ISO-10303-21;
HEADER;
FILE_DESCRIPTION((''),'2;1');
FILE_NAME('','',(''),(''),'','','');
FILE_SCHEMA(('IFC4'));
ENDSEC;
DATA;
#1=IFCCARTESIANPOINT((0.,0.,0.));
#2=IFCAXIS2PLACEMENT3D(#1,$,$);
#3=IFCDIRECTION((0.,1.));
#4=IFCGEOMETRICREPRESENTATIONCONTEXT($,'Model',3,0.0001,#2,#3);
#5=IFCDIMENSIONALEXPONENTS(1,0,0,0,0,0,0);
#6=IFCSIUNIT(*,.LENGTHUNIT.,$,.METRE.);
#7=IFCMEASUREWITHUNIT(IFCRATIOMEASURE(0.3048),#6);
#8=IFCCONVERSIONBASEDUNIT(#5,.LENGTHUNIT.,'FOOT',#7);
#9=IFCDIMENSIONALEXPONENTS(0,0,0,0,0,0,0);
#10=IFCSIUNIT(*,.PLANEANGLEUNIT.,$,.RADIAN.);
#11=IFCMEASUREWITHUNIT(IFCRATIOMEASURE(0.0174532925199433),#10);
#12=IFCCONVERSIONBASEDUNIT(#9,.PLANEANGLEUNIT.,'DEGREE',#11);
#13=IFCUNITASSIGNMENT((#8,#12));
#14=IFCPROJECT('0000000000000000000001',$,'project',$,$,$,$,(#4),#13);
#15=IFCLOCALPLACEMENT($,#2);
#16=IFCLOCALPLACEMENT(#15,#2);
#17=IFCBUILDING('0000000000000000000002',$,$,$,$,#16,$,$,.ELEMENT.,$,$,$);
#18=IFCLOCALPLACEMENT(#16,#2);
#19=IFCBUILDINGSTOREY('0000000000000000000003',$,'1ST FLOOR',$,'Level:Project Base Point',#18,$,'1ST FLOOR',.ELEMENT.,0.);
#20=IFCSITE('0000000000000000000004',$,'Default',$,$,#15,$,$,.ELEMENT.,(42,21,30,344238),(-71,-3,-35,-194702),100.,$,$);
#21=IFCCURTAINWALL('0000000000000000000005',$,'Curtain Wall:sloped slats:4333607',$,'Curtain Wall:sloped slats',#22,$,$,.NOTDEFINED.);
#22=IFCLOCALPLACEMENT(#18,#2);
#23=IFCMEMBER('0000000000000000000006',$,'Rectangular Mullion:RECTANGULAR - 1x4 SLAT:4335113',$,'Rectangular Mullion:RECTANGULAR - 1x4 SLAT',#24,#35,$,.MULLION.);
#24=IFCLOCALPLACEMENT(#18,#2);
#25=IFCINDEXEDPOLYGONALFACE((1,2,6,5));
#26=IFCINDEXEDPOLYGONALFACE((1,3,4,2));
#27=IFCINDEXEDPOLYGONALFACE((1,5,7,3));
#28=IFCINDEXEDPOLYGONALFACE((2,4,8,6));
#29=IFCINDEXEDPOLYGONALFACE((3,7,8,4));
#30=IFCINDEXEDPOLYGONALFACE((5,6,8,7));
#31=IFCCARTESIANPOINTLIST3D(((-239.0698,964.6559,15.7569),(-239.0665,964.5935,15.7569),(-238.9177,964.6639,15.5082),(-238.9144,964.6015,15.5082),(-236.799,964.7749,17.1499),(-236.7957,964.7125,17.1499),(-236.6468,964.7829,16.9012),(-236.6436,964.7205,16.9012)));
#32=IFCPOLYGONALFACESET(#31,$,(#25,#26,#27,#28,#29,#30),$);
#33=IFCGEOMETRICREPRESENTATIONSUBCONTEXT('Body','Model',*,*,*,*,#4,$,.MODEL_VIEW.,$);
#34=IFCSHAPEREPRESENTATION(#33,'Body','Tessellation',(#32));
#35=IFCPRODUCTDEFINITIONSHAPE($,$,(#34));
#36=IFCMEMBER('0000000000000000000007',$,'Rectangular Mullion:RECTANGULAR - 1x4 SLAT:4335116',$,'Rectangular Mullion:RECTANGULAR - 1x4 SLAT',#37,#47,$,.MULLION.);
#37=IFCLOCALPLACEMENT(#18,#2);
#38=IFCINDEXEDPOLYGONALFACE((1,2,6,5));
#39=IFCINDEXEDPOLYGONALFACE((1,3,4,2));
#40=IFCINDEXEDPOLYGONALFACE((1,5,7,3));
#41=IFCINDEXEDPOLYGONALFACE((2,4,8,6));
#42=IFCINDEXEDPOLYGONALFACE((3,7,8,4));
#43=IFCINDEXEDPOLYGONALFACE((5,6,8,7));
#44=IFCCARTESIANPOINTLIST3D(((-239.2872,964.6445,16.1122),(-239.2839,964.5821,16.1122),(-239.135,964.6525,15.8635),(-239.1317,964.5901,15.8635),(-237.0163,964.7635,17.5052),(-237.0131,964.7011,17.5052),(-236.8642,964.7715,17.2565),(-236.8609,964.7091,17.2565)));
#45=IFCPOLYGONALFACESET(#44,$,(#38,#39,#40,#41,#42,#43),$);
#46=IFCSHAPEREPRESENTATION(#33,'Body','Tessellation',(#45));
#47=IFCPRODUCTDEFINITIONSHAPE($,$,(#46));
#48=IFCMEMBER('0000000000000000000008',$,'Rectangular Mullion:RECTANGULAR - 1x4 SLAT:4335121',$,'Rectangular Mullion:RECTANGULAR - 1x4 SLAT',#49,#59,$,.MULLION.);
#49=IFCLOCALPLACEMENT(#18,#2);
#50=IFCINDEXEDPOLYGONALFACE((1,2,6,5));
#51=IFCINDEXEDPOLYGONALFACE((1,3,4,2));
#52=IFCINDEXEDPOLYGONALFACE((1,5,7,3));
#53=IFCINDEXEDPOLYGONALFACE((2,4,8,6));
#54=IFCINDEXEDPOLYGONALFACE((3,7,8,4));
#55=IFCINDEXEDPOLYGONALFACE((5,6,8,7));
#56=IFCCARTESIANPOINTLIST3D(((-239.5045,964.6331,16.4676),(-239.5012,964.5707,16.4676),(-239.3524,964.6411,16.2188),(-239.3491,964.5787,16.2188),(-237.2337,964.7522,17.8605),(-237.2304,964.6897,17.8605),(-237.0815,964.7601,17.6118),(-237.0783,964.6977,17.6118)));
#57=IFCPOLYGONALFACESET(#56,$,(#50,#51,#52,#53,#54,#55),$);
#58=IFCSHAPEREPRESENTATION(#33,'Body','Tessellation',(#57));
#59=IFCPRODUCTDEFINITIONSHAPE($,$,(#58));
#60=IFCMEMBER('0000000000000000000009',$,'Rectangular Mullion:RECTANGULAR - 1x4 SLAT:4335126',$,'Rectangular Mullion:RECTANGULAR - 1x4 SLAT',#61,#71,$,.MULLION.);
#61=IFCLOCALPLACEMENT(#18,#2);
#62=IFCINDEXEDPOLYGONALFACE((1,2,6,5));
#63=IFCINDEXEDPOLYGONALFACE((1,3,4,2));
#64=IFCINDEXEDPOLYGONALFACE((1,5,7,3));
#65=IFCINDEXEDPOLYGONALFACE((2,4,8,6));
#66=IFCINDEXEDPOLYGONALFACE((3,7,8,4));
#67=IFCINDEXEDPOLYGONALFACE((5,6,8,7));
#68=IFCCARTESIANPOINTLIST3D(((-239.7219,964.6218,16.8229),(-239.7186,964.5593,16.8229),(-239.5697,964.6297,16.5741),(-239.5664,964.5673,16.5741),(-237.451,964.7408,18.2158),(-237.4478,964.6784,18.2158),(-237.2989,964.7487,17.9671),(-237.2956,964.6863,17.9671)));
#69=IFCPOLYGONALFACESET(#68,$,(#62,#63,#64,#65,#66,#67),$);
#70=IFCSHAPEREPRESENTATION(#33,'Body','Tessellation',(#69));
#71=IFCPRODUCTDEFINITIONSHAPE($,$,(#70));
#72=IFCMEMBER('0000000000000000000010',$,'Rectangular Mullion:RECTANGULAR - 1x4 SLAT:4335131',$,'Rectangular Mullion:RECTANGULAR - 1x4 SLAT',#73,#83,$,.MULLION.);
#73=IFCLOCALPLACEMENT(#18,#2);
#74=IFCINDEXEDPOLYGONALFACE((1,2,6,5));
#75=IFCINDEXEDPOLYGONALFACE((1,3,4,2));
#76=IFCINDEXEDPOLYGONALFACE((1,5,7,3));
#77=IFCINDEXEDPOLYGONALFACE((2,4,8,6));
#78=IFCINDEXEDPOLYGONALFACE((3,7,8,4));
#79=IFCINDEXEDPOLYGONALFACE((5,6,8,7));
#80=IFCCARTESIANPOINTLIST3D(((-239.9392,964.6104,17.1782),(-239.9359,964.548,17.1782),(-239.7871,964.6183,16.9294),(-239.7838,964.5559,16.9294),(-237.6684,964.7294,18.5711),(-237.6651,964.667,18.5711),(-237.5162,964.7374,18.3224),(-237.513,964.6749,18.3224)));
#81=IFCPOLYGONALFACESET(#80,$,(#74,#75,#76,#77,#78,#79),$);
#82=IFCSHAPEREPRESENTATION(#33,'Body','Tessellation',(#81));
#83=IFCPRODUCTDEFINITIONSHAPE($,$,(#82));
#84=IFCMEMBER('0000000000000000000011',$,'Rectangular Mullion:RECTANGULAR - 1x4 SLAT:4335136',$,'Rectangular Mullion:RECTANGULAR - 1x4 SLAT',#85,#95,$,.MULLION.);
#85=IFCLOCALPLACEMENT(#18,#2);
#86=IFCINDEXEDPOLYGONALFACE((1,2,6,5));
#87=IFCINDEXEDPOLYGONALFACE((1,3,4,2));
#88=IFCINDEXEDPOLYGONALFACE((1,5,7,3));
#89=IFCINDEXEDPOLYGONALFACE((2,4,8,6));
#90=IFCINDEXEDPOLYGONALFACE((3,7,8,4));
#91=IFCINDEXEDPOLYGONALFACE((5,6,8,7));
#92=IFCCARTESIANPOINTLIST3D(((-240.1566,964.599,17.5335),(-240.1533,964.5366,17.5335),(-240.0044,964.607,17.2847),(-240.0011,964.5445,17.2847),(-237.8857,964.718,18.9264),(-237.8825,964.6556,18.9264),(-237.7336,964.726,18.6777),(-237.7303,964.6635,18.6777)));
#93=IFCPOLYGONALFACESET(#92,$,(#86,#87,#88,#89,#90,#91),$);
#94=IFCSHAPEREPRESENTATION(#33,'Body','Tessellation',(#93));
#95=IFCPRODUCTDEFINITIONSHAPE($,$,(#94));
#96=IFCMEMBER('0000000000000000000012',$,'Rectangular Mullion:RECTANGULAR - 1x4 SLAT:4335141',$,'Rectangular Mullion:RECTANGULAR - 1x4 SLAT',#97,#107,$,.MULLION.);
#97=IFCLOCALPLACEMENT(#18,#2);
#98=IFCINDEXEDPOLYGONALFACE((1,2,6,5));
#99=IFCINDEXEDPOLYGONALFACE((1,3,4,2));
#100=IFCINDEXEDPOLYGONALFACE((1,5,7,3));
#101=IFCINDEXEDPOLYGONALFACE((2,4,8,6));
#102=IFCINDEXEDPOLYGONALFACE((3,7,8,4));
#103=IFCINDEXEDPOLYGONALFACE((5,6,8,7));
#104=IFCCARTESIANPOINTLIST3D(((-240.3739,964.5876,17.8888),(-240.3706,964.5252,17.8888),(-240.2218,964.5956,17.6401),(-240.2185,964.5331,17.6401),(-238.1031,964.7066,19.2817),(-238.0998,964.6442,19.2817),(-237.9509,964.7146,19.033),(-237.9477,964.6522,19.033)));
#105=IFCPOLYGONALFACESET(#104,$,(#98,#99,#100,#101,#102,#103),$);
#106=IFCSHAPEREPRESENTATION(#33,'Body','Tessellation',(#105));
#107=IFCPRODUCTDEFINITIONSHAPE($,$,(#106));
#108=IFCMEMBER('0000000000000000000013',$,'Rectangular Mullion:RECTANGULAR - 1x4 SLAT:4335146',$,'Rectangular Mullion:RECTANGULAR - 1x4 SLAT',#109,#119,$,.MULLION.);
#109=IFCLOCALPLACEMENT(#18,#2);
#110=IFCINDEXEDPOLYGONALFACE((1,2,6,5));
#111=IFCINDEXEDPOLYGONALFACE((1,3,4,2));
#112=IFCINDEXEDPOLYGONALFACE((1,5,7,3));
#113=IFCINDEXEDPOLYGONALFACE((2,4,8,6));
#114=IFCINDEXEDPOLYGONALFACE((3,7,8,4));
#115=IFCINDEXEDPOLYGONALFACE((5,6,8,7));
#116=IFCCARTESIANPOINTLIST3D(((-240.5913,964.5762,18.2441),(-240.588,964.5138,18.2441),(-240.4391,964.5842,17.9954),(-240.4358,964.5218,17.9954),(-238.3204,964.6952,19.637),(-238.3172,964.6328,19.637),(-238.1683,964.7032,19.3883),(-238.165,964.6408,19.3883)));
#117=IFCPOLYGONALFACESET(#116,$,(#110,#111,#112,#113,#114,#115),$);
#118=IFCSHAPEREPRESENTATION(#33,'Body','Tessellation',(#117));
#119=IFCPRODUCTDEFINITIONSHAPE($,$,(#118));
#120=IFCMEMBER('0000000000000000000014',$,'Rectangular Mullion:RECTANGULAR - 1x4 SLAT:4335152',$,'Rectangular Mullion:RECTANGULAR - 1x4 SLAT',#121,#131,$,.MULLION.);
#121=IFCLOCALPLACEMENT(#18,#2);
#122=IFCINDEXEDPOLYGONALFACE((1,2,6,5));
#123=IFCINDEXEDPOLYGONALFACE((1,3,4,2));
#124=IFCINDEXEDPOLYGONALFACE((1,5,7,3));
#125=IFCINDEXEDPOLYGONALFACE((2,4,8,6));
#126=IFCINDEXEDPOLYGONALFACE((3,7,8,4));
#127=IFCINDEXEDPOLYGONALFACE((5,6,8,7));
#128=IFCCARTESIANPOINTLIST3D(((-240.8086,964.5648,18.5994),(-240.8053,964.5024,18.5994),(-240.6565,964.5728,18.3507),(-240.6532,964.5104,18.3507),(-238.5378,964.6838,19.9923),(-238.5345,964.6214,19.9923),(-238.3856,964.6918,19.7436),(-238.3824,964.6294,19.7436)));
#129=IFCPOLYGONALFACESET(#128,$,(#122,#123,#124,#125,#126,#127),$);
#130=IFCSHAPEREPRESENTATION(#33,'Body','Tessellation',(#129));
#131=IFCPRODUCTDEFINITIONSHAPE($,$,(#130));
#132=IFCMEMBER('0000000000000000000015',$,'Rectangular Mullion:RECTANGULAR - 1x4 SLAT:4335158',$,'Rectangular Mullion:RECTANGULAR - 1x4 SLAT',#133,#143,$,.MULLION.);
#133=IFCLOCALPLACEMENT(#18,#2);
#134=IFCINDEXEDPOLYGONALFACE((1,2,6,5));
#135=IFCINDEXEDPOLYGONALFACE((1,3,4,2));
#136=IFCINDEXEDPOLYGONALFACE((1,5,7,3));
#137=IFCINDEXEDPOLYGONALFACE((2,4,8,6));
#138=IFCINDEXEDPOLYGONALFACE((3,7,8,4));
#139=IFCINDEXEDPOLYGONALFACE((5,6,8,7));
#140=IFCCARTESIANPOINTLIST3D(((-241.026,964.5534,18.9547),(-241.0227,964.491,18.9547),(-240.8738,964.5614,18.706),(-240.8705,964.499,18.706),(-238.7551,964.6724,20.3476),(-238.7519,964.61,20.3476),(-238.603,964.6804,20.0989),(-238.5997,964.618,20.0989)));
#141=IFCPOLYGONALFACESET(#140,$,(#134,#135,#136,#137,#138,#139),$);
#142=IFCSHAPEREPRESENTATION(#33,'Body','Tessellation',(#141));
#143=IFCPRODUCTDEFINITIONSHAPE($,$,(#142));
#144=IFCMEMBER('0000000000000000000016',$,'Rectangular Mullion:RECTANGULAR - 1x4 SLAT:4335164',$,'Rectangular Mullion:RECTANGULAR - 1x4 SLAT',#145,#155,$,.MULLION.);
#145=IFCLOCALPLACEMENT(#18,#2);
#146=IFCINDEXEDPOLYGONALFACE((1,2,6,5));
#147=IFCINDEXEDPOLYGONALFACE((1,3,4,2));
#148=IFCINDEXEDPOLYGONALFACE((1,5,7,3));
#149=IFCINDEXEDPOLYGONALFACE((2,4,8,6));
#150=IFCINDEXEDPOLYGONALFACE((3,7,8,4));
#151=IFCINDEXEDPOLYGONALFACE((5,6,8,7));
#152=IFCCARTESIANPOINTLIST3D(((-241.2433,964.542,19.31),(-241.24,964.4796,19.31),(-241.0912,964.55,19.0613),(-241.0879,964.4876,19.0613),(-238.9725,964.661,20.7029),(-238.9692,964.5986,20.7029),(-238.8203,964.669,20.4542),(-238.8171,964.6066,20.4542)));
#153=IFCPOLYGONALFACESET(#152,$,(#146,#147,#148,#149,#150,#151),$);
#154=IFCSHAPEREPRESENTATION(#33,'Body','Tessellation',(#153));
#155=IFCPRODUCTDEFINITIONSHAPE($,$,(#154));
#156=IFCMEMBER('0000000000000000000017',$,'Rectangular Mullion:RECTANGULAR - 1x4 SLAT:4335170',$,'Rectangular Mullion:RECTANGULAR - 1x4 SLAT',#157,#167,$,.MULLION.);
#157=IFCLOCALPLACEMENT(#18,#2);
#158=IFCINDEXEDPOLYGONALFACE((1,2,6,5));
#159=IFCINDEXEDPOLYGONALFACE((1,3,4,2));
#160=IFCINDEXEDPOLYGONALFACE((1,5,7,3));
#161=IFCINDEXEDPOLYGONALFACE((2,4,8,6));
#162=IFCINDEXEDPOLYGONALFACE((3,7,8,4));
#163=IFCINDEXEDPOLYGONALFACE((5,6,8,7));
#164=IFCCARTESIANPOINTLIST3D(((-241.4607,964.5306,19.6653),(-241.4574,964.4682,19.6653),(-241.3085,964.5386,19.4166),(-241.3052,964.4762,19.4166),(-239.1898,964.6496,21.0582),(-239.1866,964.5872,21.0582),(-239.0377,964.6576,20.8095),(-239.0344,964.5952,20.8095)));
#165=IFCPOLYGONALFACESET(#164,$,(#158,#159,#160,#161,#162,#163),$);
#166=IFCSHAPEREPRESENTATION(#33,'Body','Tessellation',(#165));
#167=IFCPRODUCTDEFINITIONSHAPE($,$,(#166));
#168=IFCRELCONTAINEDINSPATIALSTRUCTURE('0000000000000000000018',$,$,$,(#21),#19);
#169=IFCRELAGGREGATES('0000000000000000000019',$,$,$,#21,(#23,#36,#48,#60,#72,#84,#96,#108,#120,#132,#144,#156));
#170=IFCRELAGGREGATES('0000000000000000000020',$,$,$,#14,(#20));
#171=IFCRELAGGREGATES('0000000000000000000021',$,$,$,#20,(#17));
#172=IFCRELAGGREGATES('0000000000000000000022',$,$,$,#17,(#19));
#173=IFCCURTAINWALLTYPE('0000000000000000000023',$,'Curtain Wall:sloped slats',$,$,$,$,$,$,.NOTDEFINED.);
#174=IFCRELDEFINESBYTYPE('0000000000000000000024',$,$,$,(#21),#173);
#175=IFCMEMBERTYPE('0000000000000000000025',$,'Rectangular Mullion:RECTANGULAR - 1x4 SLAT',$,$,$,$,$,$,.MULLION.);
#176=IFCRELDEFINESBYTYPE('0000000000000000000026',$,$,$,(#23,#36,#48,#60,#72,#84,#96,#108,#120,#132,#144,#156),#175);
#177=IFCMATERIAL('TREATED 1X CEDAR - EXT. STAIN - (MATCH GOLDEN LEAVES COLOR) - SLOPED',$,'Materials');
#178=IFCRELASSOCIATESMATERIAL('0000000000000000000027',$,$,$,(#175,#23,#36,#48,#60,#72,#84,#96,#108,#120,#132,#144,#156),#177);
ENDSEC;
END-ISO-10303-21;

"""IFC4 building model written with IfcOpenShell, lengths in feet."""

from ifc_helpers import new_model, entity, si_unit, converted_unit, direction, frame, frame_2d, origin, place, context, subcontext, project, spatial, rectangle, extrude, source, transform, mapped, material, material_profile, profile_set, profile_usage, type_object, type_shapes, element, aggregate, save


model = new_model("IFC4")

# Units and contexts
model_context = context("Model", 3, precision=0.0001, world=origin(), true_north=direction((0.0, 1.0)))
body_context = subcontext(model_context, "Body", "Model", "MODEL_VIEW")
ifc_project = project(units=[converted_unit("LENGTHUNIT", "FOOT", entity("IfcRatioMeasure", 0.3048), si_unit("LENGTHUNIT", "METRE"), dimensions=[1, 0, 0, 0, 0, 0, 0]), converted_unit("PLANEANGLEUNIT", "DEGREE", entity("IfcRatioMeasure", 0.0174532925199433), si_unit("PLANEANGLEUNIT", "RADIAN"), dimensions=[0, 0, 0, 0, 0, 0, 0])], contexts=[model_context])

# Site, building, storey
site_placement = place(None, origin())
site = spatial("IfcSite", under=ifc_project, at=site_placement, Name="Default", CompositionType="ELEMENT", RefLatitude=(42, 21, 30, 344238), RefLongitude=(-71, -3, -35, -194702), RefElevation=100.0)
building_placement = place(site_placement, origin())
building = spatial("IfcBuilding", under=site, at=building_placement, CompositionType="ELEMENT")
storey_placement = place(building_placement, origin())
storey = spatial("IfcBuildingStorey", under=building, at=storey_placement, Name="1ST FLOOR", ObjectType="Level:Project Base Point", LongName="1ST FLOOR", CompositionType="ELEMENT", Elevation=0.0)

# Curtain wall, members
curtain_wall_type_1 = type_object("IfcCurtainWallType", Name="Curtain Wall:sloped slats", PredefinedType="NOTDEFINED")
curtain_wall_1_placement = place(storey_placement, origin())
curtain_wall_1 = element("IfcCurtainWall", 1, at=curtain_wall_1_placement, inside=storey, type_object=curtain_wall_type_1, Name="Curtain Wall:sloped slats:4333607", ObjectType="Curtain Wall:sloped slats", PredefinedType="NOTDEFINED")
ifc_material_1 = material(Name="TREATED 1X CEDAR - EXT. STAIN - (MATCH GOLDEN LEAVES COLOR) - SLOPED", Category="Materials")
ifc_material_profile_1 = material_profile(ifc_material_1, rectangle(XDim=0.0625, YDim=0.2917, at=frame_2d((0.0, 0.0), x_axis=(1.0, 0.0))), Name="RECTANGULAR - 1x4 SLAT")
ifc_profile_set_1 = profile_set([ifc_material_profile_1], Name="RECTANGULAR - 1x4 SLAT")
member_type_1 = type_object("IfcMemberType", Name="Rectangular Mullion:RECTANGULAR - 1x4 SLAT", PredefinedType="MULLION", material=ifc_profile_set_1)
shared_shape_1 = source(origin(), body_context, "Body", "SweptSolid", [
    extrude(rectangle(XDim=0.0625, YDim=0.2917, at=frame_2d((0.0, 0.0), x_axis=(1.0, 0.0))), frame((0.0, 0.0, -2.6667), z_axis=(0.0, 0.0, 1.0), x_axis=(0.0, -1.0, 0.0)), (0.0, 0.0, 1.0), 2.6667),
])
type_shapes(member_type_1, [shared_shape_1])
ifc_profile_usage_1 = profile_usage(ifc_profile_set_1)
member_1_placement = place(storey_placement, frame((-238.9921, 964.6287, 15.6326), z_axis=(-0.851559, -0.044628, -0.522356), x_axis=(-0.52164, -0.027338, 0.852727)))
member_1 = element("IfcMember", 2, at=member_1_placement, type_object=member_type_1, material=ifc_profile_usage_1, Name="Rectangular Mullion:RECTANGULAR - 1x4 SLAT:4335113", ObjectType="Rectangular Mullion:RECTANGULAR - 1x4 SLAT", PredefinedType="MULLION", context=body_context, shape_type="MappedRepresentation", body=[
    mapped(shared_shape_1, transform((0.0, 0.0, 0.0), scale=1.0)),
])
ifc_profile_usage_2 = profile_usage(ifc_profile_set_1)
member_2_placement = place(storey_placement, frame((-239.2095, 964.6173, 15.9879), z_axis=(-0.851559, -0.044628, -0.522356), x_axis=(-0.52164, -0.027338, 0.852727)))
member_2 = element("IfcMember", 3, at=member_2_placement, type_object=member_type_1, material=ifc_profile_usage_2, Name="Rectangular Mullion:RECTANGULAR - 1x4 SLAT:4335116", ObjectType="Rectangular Mullion:RECTANGULAR - 1x4 SLAT", PredefinedType="MULLION", context=body_context, shape_type="MappedRepresentation", body=[
    mapped(shared_shape_1, transform((0.0, 0.0, 0.0), scale=1.0)),
])
ifc_profile_usage_3 = profile_usage(ifc_profile_set_1)
member_3_placement = place(storey_placement, frame((-239.4268, 964.6059, 16.3432), z_axis=(-0.851559, -0.044628, -0.522356), x_axis=(-0.52164, -0.027338, 0.852727)))
member_3 = element("IfcMember", 4, at=member_3_placement, type_object=member_type_1, material=ifc_profile_usage_3, Name="Rectangular Mullion:RECTANGULAR - 1x4 SLAT:4335121", ObjectType="Rectangular Mullion:RECTANGULAR - 1x4 SLAT", PredefinedType="MULLION", context=body_context, shape_type="MappedRepresentation", body=[
    mapped(shared_shape_1, transform((0.0, 0.0, 0.0), scale=1.0)),
])
ifc_profile_usage_4 = profile_usage(ifc_profile_set_1)
member_4_placement = place(storey_placement, frame((-239.6442, 964.5945, 16.6985), z_axis=(-0.851559, -0.044628, -0.522356), x_axis=(-0.52164, -0.027338, 0.852727)))
member_4 = element("IfcMember", 5, at=member_4_placement, type_object=member_type_1, material=ifc_profile_usage_4, Name="Rectangular Mullion:RECTANGULAR - 1x4 SLAT:4335126", ObjectType="Rectangular Mullion:RECTANGULAR - 1x4 SLAT", PredefinedType="MULLION", context=body_context, shape_type="MappedRepresentation", body=[
    mapped(shared_shape_1, transform((0.0, 0.0, 0.0), scale=1.0)),
])
ifc_profile_usage_5 = profile_usage(ifc_profile_set_1)
member_5_placement = place(storey_placement, frame((-239.8615, 964.5831, 17.0538), z_axis=(-0.851559, -0.044628, -0.522356), x_axis=(-0.52164, -0.027338, 0.852727)))
member_5 = element("IfcMember", 6, at=member_5_placement, type_object=member_type_1, material=ifc_profile_usage_5, Name="Rectangular Mullion:RECTANGULAR - 1x4 SLAT:4335131", ObjectType="Rectangular Mullion:RECTANGULAR - 1x4 SLAT", PredefinedType="MULLION", context=body_context, shape_type="MappedRepresentation", body=[
    mapped(shared_shape_1, transform((0.0, 0.0, 0.0), scale=1.0)),
])
ifc_profile_usage_6 = profile_usage(ifc_profile_set_1)
member_6_placement = place(storey_placement, frame((-240.0789, 964.5718, 17.4091), z_axis=(-0.851559, -0.044628, -0.522356), x_axis=(-0.52164, -0.027338, 0.852727)))
member_6 = element("IfcMember", 7, at=member_6_placement, type_object=member_type_1, material=ifc_profile_usage_6, Name="Rectangular Mullion:RECTANGULAR - 1x4 SLAT:4335136", ObjectType="Rectangular Mullion:RECTANGULAR - 1x4 SLAT", PredefinedType="MULLION", context=body_context, shape_type="MappedRepresentation", body=[
    mapped(shared_shape_1, transform((0.0, 0.0, 0.0), scale=1.0)),
])
ifc_profile_usage_7 = profile_usage(ifc_profile_set_1)
member_7_placement = place(storey_placement, frame((-240.2962, 964.5604, 17.7644), z_axis=(-0.851559, -0.044628, -0.522356), x_axis=(-0.52164, -0.027338, 0.852727)))
member_7 = element("IfcMember", 8, at=member_7_placement, type_object=member_type_1, material=ifc_profile_usage_7, Name="Rectangular Mullion:RECTANGULAR - 1x4 SLAT:4335141", ObjectType="Rectangular Mullion:RECTANGULAR - 1x4 SLAT", PredefinedType="MULLION", context=body_context, shape_type="MappedRepresentation", body=[
    mapped(shared_shape_1, transform((0.0, 0.0, 0.0), scale=1.0)),
])
ifc_profile_usage_8 = profile_usage(ifc_profile_set_1)
member_8_placement = place(storey_placement, frame((-240.5136, 964.549, 18.1197), z_axis=(-0.851559, -0.044628, -0.522356), x_axis=(-0.52164, -0.027338, 0.852727)))
member_8 = element("IfcMember", 9, at=member_8_placement, type_object=member_type_1, material=ifc_profile_usage_8, Name="Rectangular Mullion:RECTANGULAR - 1x4 SLAT:4335146", ObjectType="Rectangular Mullion:RECTANGULAR - 1x4 SLAT", PredefinedType="MULLION", context=body_context, shape_type="MappedRepresentation", body=[
    mapped(shared_shape_1, transform((0.0, 0.0, 0.0), scale=1.0)),
])
ifc_profile_usage_9 = profile_usage(ifc_profile_set_1)
member_9_placement = place(storey_placement, frame((-240.7309, 964.5376, 18.475), z_axis=(-0.851559, -0.044628, -0.522356), x_axis=(-0.52164, -0.027338, 0.852727)))
member_9 = element("IfcMember", 10, at=member_9_placement, type_object=member_type_1, material=ifc_profile_usage_9, Name="Rectangular Mullion:RECTANGULAR - 1x4 SLAT:4335152", ObjectType="Rectangular Mullion:RECTANGULAR - 1x4 SLAT", PredefinedType="MULLION", context=body_context, shape_type="MappedRepresentation", body=[
    mapped(shared_shape_1, transform((0.0, 0.0, 0.0), scale=1.0)),
])
ifc_profile_usage_10 = profile_usage(ifc_profile_set_1)
member_10_placement = place(storey_placement, frame((-240.9483, 964.5262, 18.8303), z_axis=(-0.851559, -0.044628, -0.522356), x_axis=(-0.52164, -0.027338, 0.852727)))
member_10 = element("IfcMember", 11, at=member_10_placement, type_object=member_type_1, material=ifc_profile_usage_10, Name="Rectangular Mullion:RECTANGULAR - 1x4 SLAT:4335158", ObjectType="Rectangular Mullion:RECTANGULAR - 1x4 SLAT", PredefinedType="MULLION", context=body_context, shape_type="MappedRepresentation", body=[
    mapped(shared_shape_1, transform((0.0, 0.0, 0.0), scale=1.0)),
])
ifc_profile_usage_11 = profile_usage(ifc_profile_set_1)
member_11_placement = place(storey_placement, frame((-241.1656, 964.5148, 19.1856), z_axis=(-0.851559, -0.044628, -0.522356), x_axis=(-0.52164, -0.027338, 0.852727)))
member_11 = element("IfcMember", 12, at=member_11_placement, type_object=member_type_1, material=ifc_profile_usage_11, Name="Rectangular Mullion:RECTANGULAR - 1x4 SLAT:4335164", ObjectType="Rectangular Mullion:RECTANGULAR - 1x4 SLAT", PredefinedType="MULLION", context=body_context, shape_type="MappedRepresentation", body=[
    mapped(shared_shape_1, transform((0.0, 0.0, 0.0), scale=1.0)),
])
ifc_profile_usage_12 = profile_usage(ifc_profile_set_1)
member_12_placement = place(storey_placement, frame((-241.383, 964.5034, 19.5409), z_axis=(-0.851559, -0.044628, -0.522356), x_axis=(-0.52164, -0.027338, 0.852727)))
member_12 = element("IfcMember", 13, at=member_12_placement, type_object=member_type_1, material=ifc_profile_usage_12, Name="Rectangular Mullion:RECTANGULAR - 1x4 SLAT:4335170", ObjectType="Rectangular Mullion:RECTANGULAR - 1x4 SLAT", PredefinedType="MULLION", context=body_context, shape_type="MappedRepresentation", body=[
    mapped(shared_shape_1, transform((0.0, 0.0, 0.0), scale=1.0)),
])
aggregate(curtain_wall_1, [member_1, member_2, member_3, member_4, member_5, member_6, member_7, member_8, member_9, member_10, member_11, member_12])

save(model, "model.ifc")
